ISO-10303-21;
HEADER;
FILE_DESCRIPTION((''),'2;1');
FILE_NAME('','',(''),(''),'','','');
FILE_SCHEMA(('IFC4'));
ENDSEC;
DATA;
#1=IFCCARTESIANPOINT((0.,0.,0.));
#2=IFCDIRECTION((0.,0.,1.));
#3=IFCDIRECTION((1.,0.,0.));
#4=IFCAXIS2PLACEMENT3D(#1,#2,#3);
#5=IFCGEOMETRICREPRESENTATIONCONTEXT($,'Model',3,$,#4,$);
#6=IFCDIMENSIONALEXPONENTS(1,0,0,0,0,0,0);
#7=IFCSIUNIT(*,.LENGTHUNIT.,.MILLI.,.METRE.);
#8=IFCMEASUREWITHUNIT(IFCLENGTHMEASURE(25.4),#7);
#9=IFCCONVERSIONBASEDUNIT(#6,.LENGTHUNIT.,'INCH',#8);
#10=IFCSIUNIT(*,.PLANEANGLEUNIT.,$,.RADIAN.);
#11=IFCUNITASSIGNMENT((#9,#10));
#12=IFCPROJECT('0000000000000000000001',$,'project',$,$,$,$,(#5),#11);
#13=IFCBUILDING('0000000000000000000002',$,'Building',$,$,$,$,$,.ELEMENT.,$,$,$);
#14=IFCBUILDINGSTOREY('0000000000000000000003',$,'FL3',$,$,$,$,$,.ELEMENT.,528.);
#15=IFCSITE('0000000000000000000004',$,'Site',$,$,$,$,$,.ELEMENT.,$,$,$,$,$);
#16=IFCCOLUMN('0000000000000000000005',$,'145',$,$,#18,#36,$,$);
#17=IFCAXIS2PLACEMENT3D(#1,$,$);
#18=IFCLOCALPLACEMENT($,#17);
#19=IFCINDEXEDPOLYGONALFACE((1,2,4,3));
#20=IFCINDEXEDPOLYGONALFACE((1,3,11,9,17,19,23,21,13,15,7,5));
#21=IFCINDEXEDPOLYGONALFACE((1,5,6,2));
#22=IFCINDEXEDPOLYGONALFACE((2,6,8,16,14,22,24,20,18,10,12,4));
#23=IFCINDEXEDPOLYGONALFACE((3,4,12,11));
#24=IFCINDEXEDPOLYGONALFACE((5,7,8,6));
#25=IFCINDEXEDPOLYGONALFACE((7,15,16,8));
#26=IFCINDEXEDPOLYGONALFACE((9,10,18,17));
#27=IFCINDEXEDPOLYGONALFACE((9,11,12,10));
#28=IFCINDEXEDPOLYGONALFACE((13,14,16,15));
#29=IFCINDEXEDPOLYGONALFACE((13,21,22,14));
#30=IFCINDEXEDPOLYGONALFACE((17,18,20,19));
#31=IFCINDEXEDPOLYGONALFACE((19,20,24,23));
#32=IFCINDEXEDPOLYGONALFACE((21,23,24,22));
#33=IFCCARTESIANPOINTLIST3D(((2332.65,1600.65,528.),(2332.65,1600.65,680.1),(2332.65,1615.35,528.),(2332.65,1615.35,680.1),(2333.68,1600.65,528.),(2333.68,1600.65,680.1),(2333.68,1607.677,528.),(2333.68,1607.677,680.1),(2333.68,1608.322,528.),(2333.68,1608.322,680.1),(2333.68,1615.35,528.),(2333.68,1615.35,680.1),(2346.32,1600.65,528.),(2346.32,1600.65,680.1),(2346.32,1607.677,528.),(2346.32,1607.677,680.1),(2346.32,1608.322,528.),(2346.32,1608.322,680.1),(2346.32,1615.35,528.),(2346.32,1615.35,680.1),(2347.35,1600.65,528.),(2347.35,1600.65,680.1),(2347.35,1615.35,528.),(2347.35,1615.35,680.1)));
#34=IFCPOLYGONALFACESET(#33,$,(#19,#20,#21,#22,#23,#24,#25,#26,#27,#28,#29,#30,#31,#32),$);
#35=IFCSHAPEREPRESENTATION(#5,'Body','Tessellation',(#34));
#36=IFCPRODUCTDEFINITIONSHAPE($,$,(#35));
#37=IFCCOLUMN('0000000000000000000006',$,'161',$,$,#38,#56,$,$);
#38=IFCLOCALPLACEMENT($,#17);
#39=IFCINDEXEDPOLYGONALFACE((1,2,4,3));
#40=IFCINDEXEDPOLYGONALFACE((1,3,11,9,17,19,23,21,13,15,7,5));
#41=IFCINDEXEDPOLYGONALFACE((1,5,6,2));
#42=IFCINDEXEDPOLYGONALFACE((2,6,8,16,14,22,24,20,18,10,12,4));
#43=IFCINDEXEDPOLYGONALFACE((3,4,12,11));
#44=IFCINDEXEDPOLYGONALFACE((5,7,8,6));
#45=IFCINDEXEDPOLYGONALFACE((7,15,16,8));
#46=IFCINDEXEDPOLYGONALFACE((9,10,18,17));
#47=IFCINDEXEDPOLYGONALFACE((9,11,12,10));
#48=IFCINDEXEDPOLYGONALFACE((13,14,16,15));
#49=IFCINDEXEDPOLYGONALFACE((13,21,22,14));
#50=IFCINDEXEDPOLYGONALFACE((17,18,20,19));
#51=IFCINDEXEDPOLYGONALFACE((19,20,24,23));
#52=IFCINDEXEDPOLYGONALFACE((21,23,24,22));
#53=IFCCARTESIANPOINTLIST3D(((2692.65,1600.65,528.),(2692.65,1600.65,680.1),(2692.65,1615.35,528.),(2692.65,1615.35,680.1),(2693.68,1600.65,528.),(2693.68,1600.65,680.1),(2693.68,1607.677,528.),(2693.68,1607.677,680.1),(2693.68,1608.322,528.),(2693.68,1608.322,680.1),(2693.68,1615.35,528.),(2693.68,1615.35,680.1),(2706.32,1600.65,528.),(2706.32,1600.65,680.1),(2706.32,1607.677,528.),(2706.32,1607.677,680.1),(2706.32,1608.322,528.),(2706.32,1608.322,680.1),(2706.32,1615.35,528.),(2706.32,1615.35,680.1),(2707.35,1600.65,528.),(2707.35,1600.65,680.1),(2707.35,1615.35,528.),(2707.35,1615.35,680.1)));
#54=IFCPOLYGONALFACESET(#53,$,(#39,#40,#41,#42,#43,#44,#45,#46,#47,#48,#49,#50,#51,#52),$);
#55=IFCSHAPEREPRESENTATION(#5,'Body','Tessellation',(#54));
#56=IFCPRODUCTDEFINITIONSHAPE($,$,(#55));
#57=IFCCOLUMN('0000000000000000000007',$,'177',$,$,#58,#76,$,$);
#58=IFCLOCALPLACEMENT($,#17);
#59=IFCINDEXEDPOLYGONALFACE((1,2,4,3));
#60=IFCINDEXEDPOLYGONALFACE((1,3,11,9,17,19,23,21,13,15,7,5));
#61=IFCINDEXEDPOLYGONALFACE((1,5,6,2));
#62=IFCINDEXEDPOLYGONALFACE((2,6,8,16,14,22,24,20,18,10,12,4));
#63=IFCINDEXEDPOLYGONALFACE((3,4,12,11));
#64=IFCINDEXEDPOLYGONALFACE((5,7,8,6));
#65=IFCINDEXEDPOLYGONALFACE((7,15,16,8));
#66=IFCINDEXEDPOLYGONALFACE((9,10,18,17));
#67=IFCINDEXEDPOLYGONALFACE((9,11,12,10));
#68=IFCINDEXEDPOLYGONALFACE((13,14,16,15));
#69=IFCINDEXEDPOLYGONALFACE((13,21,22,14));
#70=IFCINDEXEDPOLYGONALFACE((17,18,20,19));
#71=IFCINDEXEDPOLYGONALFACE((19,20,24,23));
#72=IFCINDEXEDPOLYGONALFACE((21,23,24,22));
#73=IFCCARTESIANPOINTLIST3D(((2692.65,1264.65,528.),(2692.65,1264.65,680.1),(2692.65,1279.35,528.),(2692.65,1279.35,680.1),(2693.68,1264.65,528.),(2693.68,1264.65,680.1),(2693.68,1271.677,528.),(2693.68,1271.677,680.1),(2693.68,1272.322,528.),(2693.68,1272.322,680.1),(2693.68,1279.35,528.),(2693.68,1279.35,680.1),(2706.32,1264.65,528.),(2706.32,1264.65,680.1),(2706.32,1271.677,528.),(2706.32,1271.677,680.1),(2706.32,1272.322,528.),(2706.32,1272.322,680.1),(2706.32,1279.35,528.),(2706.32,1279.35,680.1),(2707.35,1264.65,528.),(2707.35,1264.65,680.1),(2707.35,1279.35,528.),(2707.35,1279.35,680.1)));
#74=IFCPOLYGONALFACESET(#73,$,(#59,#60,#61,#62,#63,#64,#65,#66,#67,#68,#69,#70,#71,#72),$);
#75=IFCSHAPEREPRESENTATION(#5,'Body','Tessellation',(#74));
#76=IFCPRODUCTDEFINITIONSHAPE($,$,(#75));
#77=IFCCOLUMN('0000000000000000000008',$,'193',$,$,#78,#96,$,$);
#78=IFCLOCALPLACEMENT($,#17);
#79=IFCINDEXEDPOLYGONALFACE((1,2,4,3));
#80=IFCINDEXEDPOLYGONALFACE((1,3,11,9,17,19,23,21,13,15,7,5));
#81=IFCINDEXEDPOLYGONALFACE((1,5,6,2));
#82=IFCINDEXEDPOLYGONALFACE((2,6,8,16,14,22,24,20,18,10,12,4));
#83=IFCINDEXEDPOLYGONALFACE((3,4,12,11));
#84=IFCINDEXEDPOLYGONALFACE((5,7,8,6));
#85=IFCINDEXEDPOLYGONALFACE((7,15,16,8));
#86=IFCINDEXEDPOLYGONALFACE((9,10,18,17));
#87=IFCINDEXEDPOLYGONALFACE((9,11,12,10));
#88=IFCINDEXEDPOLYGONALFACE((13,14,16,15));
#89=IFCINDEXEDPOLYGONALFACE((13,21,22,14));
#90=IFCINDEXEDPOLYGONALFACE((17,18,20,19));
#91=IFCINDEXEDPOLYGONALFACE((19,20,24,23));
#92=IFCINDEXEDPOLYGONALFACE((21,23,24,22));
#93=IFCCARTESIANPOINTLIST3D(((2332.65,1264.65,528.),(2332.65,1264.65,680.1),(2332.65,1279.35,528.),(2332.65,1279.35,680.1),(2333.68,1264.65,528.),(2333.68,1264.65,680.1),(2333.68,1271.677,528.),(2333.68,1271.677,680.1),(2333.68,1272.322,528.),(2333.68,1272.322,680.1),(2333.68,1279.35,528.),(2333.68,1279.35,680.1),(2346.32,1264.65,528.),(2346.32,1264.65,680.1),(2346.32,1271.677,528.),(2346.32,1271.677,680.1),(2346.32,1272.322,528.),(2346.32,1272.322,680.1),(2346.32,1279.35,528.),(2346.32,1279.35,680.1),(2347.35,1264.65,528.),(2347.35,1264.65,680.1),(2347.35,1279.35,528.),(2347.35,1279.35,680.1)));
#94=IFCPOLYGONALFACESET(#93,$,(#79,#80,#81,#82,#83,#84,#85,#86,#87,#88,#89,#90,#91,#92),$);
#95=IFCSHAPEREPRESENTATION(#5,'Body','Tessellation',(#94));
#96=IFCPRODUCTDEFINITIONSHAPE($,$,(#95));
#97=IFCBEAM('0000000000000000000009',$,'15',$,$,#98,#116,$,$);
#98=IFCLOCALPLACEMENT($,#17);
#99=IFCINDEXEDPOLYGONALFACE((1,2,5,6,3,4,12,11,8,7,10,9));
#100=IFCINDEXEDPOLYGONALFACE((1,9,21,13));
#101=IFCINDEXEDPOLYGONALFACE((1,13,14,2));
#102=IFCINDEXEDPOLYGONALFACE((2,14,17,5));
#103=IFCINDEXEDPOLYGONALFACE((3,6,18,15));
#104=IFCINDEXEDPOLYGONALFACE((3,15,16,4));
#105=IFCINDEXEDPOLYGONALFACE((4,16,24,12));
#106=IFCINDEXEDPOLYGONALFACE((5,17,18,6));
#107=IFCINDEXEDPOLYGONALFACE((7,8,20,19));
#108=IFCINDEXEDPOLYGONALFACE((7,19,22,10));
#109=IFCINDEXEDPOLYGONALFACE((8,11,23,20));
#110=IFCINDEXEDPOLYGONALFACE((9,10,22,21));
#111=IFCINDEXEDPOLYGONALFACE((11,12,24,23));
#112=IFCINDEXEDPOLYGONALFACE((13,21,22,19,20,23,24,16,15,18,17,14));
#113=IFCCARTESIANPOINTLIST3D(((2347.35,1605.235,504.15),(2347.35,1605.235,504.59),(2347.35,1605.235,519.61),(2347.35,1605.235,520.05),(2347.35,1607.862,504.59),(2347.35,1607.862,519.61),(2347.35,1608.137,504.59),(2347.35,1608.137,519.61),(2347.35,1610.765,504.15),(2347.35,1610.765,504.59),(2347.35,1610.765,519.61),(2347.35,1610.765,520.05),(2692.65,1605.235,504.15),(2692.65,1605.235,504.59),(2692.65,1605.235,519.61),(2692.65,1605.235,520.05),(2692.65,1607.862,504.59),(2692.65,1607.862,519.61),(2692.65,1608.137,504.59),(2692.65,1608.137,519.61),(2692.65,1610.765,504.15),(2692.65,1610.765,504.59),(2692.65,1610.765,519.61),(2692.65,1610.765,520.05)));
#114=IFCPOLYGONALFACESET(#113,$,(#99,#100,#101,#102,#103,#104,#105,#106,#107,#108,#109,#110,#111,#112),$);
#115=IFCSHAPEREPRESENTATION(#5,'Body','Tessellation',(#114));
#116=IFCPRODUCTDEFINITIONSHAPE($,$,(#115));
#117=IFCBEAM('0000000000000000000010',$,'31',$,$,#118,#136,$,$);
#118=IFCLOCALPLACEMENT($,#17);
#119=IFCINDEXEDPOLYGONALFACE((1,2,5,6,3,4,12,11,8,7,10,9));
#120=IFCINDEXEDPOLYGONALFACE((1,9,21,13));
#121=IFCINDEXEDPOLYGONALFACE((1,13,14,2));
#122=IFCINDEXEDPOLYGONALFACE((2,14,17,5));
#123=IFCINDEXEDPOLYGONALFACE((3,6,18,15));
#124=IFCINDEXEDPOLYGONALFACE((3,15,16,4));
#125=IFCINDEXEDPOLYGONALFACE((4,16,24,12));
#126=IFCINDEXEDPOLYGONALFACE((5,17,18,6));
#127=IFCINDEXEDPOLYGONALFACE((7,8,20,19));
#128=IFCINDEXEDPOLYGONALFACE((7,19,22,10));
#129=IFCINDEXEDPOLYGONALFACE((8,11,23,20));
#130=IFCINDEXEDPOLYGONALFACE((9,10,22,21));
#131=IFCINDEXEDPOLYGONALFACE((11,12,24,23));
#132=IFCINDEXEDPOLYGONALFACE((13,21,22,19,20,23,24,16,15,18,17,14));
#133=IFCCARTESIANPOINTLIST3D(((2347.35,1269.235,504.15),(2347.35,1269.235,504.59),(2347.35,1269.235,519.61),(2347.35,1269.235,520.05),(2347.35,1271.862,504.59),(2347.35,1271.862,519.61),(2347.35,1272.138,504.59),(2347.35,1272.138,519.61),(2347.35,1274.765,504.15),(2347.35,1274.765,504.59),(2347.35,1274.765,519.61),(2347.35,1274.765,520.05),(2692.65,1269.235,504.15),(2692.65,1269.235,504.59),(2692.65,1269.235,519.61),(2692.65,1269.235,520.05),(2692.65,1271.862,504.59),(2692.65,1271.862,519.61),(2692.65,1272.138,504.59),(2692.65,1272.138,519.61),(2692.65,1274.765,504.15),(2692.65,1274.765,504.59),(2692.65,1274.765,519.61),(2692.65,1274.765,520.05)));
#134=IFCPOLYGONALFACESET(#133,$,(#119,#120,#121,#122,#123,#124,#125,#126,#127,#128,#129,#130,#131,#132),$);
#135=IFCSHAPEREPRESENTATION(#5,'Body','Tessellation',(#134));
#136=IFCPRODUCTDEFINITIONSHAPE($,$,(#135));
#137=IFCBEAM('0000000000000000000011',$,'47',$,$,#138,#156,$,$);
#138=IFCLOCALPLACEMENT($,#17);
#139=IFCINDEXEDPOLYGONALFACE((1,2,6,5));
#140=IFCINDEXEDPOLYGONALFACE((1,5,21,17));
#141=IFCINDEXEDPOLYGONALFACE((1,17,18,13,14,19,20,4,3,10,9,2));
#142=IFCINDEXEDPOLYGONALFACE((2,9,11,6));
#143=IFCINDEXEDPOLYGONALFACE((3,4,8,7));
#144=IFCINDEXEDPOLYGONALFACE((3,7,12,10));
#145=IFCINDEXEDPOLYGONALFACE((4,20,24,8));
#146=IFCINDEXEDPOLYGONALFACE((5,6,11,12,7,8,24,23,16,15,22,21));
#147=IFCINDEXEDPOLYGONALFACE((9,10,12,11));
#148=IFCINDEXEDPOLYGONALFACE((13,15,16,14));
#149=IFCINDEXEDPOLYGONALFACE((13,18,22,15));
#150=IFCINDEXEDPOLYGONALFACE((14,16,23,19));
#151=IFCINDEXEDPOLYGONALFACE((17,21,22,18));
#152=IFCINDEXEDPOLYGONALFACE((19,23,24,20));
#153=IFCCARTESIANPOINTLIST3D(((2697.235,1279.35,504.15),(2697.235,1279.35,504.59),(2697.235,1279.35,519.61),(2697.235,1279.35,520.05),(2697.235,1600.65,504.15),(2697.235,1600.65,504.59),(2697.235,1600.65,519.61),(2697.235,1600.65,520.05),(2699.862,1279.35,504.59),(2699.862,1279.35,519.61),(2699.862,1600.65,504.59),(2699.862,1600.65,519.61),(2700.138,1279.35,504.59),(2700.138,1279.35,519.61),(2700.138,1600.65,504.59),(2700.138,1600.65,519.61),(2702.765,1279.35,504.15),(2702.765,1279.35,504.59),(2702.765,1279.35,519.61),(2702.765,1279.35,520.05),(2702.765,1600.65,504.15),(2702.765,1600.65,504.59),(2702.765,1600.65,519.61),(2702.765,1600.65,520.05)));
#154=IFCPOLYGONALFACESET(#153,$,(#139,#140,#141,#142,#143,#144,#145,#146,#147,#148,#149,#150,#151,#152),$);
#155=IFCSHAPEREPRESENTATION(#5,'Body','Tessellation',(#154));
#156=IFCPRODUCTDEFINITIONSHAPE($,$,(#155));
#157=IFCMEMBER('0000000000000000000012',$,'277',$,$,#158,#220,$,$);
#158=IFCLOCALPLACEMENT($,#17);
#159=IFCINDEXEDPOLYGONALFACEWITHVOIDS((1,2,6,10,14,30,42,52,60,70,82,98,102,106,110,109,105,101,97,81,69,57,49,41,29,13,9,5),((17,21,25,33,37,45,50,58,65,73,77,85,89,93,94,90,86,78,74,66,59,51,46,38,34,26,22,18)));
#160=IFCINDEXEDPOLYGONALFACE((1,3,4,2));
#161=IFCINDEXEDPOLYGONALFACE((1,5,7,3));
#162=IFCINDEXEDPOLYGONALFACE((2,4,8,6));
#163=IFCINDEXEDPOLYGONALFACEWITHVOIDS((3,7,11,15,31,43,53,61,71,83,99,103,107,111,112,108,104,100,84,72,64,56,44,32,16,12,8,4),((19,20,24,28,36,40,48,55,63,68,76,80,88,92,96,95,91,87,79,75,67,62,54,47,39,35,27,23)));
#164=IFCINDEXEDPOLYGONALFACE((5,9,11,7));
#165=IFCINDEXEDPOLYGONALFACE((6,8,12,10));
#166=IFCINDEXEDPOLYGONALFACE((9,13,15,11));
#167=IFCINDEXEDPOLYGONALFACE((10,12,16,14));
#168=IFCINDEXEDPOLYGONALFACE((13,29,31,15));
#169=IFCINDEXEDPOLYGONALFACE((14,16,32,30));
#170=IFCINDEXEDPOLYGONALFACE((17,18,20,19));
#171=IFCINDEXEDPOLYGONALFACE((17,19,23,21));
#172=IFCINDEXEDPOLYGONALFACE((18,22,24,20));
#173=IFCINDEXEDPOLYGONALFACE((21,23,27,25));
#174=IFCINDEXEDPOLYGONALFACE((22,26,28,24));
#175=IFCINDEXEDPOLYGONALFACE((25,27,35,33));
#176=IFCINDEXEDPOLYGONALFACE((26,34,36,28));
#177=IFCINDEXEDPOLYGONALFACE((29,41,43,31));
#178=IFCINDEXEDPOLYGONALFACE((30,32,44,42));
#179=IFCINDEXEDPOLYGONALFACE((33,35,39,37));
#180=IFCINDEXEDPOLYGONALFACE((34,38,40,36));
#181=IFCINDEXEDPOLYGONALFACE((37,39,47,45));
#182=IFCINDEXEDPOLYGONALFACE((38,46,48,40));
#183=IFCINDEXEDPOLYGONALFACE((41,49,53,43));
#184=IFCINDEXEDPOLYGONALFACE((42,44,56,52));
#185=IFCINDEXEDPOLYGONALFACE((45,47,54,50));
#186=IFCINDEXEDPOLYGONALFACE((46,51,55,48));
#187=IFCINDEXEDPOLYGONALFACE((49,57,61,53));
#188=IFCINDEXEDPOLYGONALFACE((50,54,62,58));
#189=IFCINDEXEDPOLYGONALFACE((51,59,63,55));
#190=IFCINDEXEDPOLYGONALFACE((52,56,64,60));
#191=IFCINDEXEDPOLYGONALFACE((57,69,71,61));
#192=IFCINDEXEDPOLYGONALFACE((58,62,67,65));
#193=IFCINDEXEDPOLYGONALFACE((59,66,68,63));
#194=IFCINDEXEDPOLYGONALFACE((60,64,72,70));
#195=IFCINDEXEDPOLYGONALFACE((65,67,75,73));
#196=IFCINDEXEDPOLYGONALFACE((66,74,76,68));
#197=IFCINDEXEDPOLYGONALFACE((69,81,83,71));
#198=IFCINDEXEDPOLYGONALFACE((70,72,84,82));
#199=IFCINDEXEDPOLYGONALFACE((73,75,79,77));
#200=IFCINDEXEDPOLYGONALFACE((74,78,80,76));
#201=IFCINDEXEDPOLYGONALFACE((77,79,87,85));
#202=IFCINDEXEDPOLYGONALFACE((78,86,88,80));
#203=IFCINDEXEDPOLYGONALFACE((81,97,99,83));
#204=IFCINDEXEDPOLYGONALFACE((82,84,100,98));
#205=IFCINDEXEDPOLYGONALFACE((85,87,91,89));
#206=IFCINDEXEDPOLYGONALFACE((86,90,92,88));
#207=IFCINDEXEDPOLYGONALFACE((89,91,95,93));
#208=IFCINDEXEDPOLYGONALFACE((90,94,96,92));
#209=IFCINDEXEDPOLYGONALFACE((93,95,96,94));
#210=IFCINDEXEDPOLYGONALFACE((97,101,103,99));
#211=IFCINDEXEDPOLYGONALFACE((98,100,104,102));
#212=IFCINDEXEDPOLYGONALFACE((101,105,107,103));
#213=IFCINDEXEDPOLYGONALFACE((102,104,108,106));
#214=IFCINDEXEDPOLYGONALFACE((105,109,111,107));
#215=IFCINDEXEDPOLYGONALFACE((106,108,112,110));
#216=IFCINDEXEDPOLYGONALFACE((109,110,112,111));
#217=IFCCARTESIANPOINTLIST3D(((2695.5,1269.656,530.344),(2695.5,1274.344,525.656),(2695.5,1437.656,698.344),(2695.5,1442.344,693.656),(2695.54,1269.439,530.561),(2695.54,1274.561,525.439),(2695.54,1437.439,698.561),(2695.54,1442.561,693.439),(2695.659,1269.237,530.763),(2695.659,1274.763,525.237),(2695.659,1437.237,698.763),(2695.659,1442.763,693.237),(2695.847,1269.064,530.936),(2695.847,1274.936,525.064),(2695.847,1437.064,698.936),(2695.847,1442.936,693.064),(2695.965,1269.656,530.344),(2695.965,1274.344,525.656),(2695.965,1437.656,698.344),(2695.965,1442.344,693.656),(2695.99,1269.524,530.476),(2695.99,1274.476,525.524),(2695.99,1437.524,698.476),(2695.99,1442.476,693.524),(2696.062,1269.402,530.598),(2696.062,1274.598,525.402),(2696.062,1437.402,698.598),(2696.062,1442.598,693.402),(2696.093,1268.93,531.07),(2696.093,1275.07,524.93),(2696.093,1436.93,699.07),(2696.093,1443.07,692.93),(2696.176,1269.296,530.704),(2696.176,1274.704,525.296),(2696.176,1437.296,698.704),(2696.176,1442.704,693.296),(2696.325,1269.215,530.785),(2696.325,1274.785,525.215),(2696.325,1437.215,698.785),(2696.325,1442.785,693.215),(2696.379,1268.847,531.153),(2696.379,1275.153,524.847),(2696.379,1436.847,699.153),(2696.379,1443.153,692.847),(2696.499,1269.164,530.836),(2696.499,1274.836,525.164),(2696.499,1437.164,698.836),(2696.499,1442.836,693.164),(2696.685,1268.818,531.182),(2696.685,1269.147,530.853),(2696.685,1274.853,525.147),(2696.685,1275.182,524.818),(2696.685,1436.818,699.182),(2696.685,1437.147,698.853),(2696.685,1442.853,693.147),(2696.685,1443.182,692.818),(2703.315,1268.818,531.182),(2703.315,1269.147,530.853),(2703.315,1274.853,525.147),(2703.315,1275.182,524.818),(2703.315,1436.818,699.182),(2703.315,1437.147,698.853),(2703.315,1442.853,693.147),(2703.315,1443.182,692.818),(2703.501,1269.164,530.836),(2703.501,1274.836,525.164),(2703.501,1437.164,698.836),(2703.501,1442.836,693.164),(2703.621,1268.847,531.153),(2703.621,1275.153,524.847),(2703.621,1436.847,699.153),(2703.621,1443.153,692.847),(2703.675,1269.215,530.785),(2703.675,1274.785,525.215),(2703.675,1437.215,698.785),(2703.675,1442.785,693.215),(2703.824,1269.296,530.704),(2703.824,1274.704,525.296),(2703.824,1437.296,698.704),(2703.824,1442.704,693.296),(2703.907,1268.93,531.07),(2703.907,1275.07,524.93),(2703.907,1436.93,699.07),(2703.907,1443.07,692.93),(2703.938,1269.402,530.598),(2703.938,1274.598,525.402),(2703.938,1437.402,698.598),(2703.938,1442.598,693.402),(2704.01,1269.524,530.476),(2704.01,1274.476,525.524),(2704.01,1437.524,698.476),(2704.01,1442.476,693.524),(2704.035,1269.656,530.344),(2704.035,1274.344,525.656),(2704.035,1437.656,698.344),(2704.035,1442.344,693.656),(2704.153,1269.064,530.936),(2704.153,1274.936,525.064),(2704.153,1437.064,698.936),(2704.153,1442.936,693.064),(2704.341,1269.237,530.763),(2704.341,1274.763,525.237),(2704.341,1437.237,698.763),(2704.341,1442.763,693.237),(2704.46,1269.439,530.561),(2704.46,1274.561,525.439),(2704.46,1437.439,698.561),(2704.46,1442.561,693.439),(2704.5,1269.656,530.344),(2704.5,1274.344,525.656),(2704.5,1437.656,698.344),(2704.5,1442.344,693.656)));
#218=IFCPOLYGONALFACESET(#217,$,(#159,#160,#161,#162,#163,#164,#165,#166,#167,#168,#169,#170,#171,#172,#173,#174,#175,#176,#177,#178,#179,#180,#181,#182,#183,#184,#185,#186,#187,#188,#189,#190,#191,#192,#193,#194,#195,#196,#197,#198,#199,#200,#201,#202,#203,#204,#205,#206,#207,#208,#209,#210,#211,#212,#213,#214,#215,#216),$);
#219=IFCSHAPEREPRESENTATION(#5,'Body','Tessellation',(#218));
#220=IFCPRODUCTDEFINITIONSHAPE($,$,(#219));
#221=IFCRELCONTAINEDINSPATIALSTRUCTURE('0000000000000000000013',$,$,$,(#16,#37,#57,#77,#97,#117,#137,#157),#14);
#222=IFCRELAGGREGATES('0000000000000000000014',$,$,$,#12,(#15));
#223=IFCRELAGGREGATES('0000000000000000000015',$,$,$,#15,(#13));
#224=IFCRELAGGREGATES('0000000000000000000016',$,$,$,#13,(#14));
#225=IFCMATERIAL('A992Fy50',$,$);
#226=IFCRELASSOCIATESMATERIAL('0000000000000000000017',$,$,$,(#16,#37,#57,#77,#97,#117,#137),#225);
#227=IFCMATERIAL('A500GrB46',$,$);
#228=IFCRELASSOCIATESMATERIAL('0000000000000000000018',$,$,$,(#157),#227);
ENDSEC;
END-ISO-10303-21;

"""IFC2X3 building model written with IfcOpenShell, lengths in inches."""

from ifc_helpers import new_model, entity, si_unit, converted_unit, frame, origin_with_axes, origin_2d_with_axis, place, context, project, spatial, hollow_rectangle, i_section, transform_2d, derived_profile, extrude, material, element, save


model = new_model("IFC2X3")

# Units and contexts
model_context = context("Model", 3, world=origin_with_axes())
ifc_project = project(units=[converted_unit("LENGTHUNIT", "INCH", entity("IfcLengthMeasure", 25.4), si_unit("LENGTHUNIT", "METRE", prefix="MILLI"), dimensions=[1, 0, 0, 0, 0, 0, 0]), si_unit("PLANEANGLEUNIT", "RADIAN")], contexts=[model_context])

# Site, building, storey
site = spatial("IfcSite", under=ifc_project, Name="Site", CompositionType="ELEMENT")
building = spatial("IfcBuilding", under=site, Name="Building", CompositionType="ELEMENT")
storey = spatial("IfcBuildingStorey", under=building, Name="FL3", CompositionType="ELEMENT", Elevation=528.0)

# Columns
ifc_material_1 = material(Name="A992Fy50")
for number, where, z_axis, x_axis, name in (
    (1, (2340.0, 1608.0, 528.0), (0.0, 0.0, 1.0), (0.0, -1.0, 0.0), "145"),
    (2, (2700.0, 1608.0, 528.0), (0.0, 0.0, 1.0), (0.0, -1.0, 0.0), "161"),
    (3, (2700.0, 1272.0, 528.0), (0.0, 0.0, 1.0), (0.0, -1.0, 0.0), "177"),
    (4, (2340.0, 1272.0, 528.0), (0.0, 0.0, 1.0), (0.0, -1.0, 0.0), "193"),
):
    element("IfcColumn", number, at=place(None, frame(where, z_axis=z_axis, x_axis=x_axis)), inside=storey, material=ifc_material_1, Name=name, context=model_context, shape_type="SweptSolid", body=[
        extrude(i_section(OverallWidth=14.7, OverallDepth=14.7, WebThickness=0.645, FlangeThickness=1.03, at=origin_2d_with_axis()), origin_with_axes(), (0.0, 0.0, 1.0), 152.1),
    ])

# Beams
for number, where, z_axis, x_axis, name in (
    (5, (2347.35, 1608.0, 528.0), (1.0, 0.0, 0.0), (0.0, 1.0, 0.0), "15"),
    (6, (2347.35, 1272.0, 528.0), (1.0, 0.0, 0.0), (0.0, 1.0, 0.0), "31"),
):
    element("IfcBeam", number, at=place(None, frame(where, z_axis=z_axis, x_axis=x_axis)), inside=storey, material=ifc_material_1, Name=name, context=model_context, shape_type="SweptSolid", body=[
        extrude(derived_profile(i_section(OverallWidth=5.53, OverallDepth=15.9, WebThickness=0.275, FlangeThickness=0.44, at=origin_2d_with_axis()), transform_2d((0.0, -7.95))), origin_with_axes(), (0.0, 0.0, 1.0), 345.3),
    ])
beam_placement = place(None, frame((2700.0, 1279.35, 528.0), z_axis=(0.0, 1.0, 0.0), x_axis=(-1.0, 0.0, 0.0)))
element("IfcBeam", 7, at=beam_placement, inside=storey, material=ifc_material_1, Name="47", context=model_context, shape_type="SweptSolid", body=[
    extrude(derived_profile(i_section(OverallWidth=5.53, OverallDepth=15.9, WebThickness=0.275, FlangeThickness=0.44, at=origin_2d_with_axis()), transform_2d((0.0, -7.95))), origin_with_axes(), (0.0, 0.0, 1.0), 321.3),
])

# Member
ifc_material_2 = material(Name="A500GrB46")
for number, where, z_axis, x_axis, name in (
    (8, (2700.0, 1272.0, 528.0), (0.0, 0.707107, 0.707107), (-1.0, 0.0, 0.0), "277"),
):
    element("IfcMember", number, at=place(None, frame(where, z_axis=z_axis, x_axis=x_axis)), inside=storey, material=ifc_material_2, Name=name, context=model_context, shape_type="SweptSolid", body=[
        extrude(hollow_rectangle(XDim=9.0, YDim=9.0, WallThickness=0.465, InnerFilletRadius=0.72, OuterFilletRadius=1.185, at=origin_2d_with_axis()), origin_with_axes(), (0.0, 0.0, 1.0), 237.588),
    ])

save(model, "model.ifc")
